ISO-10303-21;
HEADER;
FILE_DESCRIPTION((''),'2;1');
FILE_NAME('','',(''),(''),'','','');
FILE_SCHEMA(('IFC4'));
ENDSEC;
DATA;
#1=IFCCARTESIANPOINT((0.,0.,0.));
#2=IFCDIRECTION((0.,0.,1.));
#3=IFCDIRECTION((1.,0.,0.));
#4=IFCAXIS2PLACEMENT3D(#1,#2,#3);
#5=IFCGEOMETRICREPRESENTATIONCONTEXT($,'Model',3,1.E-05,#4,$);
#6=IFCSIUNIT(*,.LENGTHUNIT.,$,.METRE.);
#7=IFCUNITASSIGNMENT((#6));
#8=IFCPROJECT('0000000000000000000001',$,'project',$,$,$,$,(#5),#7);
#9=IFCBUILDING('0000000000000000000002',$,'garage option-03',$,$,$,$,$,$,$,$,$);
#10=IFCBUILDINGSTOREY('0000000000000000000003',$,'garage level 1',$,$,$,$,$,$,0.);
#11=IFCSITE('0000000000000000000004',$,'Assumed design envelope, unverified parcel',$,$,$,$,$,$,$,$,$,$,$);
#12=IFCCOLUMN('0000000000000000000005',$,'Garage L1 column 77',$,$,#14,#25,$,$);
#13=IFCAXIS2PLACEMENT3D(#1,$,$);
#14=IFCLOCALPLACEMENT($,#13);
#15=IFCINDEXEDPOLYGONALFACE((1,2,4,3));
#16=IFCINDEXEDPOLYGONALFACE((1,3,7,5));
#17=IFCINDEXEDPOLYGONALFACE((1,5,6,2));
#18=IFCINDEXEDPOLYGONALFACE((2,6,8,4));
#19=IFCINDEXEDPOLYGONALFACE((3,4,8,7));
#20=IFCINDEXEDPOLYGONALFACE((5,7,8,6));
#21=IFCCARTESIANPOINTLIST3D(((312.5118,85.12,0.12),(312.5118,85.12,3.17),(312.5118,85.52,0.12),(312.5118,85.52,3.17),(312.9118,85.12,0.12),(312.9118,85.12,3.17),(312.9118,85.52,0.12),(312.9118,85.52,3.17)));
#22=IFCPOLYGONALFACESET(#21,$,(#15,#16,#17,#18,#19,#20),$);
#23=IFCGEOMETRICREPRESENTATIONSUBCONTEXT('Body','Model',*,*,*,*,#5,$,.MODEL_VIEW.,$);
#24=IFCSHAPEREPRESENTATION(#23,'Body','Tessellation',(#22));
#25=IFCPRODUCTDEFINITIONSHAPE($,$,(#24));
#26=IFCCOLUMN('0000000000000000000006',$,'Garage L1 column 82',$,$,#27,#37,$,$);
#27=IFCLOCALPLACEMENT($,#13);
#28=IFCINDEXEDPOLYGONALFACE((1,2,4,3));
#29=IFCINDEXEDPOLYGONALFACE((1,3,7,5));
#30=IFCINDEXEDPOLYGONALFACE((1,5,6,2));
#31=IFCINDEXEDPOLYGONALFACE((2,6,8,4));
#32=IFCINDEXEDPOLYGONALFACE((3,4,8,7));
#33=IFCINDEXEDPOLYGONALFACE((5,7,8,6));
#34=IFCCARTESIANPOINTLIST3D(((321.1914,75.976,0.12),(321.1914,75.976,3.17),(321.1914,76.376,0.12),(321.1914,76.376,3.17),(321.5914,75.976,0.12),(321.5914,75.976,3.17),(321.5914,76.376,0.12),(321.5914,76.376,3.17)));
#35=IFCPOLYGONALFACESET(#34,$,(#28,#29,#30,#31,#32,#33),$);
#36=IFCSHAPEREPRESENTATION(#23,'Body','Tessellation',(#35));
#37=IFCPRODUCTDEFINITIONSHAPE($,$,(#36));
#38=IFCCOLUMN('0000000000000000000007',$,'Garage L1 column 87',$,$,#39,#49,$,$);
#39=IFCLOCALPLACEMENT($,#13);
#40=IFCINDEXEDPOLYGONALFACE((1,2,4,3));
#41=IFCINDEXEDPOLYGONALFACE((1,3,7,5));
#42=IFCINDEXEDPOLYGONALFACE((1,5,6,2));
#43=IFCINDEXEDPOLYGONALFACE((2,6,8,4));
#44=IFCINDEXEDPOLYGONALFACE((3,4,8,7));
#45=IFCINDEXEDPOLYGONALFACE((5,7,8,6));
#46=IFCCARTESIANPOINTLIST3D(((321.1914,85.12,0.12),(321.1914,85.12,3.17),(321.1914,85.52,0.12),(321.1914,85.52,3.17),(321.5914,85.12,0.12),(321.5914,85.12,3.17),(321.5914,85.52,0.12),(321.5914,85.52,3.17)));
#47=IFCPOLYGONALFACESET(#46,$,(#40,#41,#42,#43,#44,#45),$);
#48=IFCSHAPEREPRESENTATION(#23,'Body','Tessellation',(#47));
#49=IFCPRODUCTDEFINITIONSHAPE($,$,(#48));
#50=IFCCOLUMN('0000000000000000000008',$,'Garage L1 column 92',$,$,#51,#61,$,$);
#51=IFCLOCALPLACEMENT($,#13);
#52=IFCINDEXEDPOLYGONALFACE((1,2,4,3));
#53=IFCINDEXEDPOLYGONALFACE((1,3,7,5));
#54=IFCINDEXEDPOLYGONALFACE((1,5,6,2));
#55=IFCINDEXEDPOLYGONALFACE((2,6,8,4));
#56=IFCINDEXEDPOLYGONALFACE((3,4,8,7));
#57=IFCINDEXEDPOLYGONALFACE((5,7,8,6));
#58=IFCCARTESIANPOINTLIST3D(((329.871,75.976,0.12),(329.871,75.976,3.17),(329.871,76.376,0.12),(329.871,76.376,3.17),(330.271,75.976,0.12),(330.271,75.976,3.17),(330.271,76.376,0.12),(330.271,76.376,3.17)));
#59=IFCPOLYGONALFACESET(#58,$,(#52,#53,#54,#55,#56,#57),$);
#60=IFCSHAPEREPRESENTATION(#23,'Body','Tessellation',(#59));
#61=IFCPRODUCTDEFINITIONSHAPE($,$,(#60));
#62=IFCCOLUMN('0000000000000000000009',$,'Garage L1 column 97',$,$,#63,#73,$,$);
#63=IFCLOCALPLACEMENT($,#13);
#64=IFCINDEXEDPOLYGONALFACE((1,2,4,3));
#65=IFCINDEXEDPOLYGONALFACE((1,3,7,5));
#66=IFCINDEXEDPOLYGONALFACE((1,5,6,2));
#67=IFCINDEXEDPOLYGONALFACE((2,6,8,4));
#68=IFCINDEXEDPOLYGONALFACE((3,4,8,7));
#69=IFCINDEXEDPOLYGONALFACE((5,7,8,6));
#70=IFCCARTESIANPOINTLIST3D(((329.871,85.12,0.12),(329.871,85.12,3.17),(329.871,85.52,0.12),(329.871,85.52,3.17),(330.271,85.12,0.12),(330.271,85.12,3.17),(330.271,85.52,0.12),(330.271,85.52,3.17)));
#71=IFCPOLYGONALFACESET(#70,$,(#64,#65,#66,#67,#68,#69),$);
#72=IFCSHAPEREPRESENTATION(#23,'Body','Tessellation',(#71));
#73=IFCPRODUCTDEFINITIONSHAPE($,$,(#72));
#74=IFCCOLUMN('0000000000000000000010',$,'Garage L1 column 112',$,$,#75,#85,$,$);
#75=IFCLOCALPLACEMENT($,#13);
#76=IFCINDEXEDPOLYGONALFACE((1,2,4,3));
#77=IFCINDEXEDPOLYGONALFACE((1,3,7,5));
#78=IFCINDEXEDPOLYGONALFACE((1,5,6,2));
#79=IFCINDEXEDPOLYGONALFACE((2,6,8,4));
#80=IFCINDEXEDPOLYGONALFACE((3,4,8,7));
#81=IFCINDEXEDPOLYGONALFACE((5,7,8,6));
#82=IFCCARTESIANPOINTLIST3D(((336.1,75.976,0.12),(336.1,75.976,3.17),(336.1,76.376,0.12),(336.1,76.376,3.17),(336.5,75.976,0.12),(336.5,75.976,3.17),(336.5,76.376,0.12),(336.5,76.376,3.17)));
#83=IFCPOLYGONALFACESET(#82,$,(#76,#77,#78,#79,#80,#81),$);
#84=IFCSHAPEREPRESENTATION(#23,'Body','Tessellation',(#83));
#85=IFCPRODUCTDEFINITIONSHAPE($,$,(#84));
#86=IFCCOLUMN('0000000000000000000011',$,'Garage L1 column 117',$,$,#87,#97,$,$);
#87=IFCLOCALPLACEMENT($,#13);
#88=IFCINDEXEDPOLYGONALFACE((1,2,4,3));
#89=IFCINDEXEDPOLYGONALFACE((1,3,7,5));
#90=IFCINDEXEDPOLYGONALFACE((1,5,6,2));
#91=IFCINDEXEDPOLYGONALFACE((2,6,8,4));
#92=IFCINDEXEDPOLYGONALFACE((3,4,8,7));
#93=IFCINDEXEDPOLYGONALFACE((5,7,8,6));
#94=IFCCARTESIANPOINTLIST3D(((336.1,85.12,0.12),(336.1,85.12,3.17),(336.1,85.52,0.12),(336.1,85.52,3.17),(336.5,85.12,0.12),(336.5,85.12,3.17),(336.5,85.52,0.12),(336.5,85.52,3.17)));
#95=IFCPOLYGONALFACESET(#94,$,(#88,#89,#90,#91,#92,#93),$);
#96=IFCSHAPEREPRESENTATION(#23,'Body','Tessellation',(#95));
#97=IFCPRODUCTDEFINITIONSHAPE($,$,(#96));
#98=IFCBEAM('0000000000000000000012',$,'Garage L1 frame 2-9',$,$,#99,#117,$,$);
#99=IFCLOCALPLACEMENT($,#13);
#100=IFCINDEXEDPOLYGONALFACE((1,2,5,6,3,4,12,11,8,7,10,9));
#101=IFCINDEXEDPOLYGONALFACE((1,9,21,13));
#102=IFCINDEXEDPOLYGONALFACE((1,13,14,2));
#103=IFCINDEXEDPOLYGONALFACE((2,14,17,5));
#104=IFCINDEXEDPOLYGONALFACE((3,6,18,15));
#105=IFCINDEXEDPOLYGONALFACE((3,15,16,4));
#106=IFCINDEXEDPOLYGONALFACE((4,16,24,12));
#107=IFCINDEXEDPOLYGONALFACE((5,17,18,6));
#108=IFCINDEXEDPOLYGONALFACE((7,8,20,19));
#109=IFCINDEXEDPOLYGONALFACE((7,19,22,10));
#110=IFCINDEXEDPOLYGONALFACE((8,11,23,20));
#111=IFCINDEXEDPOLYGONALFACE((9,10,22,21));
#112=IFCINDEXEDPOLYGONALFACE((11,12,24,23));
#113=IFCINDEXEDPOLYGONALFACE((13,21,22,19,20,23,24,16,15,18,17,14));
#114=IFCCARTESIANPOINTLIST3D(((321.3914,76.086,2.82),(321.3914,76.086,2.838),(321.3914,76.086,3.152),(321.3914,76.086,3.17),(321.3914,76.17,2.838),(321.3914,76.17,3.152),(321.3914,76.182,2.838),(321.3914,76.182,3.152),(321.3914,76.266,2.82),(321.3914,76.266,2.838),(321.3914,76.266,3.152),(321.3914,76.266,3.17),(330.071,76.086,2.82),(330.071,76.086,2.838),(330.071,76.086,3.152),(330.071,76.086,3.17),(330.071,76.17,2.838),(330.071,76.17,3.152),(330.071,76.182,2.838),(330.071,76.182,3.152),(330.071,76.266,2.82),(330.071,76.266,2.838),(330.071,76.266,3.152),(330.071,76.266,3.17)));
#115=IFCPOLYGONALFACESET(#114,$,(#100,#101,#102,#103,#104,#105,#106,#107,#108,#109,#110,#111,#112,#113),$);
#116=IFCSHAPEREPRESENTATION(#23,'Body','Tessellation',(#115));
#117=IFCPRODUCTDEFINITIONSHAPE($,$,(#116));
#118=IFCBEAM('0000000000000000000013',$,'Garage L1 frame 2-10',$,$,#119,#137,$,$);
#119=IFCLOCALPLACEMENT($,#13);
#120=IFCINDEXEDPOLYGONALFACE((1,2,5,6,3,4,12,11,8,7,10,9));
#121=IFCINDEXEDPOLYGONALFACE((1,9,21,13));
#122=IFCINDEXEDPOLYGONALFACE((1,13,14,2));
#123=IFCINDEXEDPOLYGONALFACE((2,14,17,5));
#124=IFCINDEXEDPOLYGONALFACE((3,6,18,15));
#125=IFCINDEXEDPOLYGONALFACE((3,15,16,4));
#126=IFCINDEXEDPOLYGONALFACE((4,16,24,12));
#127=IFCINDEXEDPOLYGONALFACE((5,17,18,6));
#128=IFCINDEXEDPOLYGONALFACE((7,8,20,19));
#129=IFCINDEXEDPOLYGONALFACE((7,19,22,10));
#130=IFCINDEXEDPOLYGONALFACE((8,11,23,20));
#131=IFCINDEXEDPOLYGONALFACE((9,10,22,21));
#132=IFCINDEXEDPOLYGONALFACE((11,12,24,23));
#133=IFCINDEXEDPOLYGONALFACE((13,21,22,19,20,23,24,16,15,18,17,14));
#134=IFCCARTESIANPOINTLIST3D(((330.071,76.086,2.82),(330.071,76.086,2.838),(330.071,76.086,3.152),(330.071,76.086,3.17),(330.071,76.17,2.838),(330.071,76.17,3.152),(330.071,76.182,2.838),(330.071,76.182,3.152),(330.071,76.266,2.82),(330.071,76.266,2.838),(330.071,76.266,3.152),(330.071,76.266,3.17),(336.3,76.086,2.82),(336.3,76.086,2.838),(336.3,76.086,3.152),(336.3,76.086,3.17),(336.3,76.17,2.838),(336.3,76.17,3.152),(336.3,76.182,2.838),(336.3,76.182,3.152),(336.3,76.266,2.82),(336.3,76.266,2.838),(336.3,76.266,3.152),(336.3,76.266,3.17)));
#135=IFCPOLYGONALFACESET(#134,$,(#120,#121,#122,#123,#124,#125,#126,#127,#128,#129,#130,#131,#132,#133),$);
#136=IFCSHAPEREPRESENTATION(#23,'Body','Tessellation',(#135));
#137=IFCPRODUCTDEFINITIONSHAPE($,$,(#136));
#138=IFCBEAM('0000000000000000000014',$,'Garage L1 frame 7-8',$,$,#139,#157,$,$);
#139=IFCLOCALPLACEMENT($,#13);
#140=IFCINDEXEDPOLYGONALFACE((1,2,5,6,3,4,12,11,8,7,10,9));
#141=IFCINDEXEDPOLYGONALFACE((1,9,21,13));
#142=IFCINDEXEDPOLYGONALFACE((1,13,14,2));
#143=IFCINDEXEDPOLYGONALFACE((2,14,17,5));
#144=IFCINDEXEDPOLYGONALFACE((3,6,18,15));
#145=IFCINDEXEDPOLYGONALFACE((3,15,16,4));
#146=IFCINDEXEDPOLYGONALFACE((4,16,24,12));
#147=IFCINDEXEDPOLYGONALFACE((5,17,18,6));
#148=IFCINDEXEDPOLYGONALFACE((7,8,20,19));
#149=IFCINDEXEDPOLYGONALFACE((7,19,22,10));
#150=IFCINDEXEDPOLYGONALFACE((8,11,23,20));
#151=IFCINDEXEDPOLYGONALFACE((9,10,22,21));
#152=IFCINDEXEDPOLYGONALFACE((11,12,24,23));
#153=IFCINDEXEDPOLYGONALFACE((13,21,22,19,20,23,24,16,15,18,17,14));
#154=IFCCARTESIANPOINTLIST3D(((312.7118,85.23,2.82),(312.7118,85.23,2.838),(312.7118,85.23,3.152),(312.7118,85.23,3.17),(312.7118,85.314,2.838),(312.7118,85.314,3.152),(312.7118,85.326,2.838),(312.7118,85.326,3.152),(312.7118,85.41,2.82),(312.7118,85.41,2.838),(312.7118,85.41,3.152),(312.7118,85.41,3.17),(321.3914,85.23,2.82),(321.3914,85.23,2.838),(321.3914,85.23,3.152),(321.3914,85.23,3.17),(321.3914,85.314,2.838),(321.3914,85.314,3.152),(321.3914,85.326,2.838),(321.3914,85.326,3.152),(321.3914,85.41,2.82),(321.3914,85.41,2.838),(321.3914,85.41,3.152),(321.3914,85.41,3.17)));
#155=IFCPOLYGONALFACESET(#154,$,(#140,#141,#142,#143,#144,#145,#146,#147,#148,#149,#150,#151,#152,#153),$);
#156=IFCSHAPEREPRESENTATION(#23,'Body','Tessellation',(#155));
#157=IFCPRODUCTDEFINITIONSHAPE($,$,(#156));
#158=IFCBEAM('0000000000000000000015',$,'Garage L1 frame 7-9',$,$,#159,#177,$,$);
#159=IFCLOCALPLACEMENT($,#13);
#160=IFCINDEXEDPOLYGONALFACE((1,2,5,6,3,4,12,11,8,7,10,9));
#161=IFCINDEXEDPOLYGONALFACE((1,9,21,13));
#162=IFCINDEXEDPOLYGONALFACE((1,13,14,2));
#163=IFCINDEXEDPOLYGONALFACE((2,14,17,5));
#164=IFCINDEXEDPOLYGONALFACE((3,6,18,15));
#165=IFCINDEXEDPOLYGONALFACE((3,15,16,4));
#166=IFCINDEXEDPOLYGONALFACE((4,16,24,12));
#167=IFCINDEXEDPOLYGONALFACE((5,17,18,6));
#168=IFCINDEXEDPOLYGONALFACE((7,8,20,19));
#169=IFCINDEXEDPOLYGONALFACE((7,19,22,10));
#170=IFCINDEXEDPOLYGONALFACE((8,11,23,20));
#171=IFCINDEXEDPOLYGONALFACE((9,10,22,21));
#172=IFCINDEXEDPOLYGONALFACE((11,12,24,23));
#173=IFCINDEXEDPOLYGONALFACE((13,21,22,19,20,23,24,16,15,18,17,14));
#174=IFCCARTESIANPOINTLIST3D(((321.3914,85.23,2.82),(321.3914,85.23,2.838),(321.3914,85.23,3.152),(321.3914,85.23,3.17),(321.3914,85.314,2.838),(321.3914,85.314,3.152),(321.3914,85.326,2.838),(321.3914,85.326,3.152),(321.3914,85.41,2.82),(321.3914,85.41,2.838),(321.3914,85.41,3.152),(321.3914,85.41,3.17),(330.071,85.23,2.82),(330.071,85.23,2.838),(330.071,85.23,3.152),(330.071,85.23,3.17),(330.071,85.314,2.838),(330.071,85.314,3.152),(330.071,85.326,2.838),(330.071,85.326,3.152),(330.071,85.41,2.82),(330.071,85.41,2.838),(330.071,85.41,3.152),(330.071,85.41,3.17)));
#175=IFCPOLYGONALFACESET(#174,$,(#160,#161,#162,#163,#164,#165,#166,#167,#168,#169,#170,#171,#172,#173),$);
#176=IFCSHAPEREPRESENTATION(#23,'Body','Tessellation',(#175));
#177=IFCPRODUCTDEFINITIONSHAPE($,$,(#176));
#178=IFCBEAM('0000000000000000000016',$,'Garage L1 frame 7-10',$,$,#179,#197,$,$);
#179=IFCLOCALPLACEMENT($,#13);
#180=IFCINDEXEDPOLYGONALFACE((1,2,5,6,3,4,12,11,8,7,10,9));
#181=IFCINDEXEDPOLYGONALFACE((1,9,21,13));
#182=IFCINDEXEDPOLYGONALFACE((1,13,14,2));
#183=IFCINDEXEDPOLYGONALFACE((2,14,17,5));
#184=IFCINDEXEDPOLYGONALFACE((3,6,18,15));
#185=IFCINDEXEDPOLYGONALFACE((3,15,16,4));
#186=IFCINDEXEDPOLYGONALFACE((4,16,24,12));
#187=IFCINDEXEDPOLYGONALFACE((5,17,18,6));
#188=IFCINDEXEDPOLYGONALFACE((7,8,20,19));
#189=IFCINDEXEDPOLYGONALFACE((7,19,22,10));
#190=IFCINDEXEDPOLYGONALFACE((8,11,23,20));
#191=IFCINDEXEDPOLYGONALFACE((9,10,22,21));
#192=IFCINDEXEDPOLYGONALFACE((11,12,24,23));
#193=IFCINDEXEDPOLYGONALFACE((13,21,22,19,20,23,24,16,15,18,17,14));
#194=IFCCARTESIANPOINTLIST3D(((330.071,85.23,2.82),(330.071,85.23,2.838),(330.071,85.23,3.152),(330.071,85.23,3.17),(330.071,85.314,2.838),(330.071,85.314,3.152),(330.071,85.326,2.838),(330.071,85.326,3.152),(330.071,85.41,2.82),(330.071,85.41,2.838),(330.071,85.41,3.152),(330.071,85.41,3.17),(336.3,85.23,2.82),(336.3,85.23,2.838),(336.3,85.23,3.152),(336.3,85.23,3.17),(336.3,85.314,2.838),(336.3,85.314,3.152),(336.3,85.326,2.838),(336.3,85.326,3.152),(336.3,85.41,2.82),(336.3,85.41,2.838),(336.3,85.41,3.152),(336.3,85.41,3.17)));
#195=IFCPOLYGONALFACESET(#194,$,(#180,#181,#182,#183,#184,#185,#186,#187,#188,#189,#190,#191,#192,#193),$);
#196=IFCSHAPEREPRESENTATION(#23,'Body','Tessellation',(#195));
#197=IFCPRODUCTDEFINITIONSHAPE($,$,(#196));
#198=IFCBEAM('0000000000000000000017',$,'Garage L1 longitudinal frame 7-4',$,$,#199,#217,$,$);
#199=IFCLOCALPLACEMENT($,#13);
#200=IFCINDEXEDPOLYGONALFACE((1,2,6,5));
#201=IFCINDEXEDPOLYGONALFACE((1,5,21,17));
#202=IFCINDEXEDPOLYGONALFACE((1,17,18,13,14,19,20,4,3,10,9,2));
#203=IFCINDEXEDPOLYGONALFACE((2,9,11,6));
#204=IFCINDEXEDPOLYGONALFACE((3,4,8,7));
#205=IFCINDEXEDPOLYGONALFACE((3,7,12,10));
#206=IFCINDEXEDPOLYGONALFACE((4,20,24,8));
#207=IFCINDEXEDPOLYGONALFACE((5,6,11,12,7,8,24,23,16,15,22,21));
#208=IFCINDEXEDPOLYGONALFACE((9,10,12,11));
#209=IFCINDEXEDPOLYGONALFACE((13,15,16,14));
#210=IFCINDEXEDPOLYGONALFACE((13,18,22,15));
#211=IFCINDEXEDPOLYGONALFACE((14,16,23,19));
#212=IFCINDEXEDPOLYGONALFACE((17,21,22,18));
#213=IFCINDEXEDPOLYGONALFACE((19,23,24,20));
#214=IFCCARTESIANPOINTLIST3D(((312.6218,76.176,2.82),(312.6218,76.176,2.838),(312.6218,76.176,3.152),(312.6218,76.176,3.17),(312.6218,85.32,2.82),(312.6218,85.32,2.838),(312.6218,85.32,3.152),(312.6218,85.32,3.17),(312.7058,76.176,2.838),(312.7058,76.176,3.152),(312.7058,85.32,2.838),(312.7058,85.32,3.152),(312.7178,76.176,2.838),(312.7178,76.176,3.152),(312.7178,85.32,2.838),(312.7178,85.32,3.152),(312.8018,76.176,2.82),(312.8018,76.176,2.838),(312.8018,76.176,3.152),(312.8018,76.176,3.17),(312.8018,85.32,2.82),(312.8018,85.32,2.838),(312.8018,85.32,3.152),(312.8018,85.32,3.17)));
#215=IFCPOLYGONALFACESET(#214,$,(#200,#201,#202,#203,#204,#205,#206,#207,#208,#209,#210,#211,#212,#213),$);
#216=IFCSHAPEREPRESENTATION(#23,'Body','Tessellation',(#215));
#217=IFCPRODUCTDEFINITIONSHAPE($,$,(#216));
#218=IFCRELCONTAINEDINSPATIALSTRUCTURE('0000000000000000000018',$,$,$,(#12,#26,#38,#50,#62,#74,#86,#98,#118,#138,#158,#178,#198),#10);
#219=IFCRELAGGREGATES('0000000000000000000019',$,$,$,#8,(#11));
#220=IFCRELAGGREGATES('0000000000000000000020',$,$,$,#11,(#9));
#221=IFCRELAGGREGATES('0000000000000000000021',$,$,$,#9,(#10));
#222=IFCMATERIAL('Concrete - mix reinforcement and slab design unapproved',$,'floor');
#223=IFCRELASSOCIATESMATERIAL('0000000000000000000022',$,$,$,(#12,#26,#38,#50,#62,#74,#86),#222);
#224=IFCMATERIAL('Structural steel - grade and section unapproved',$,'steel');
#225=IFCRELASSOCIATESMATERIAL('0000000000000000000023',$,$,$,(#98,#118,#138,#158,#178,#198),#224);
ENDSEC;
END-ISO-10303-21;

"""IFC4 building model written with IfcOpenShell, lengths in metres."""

from ifc_helpers import new_model, si_unit, frame, origin_with_axes, place, context, subcontext, project, spatial, rectangle, i_section, extrude, material, element, save


model = new_model("IFC4")

# Units and contexts
model_context = context("Model", 3, precision=1e-05, world=origin_with_axes())
body_context = subcontext(model_context, "Body", "Model", "MODEL_VIEW")
ifc_project = project(units=[si_unit("LENGTHUNIT", "METRE")], contexts=[model_context])

# Site, building, storey
site = spatial("IfcSite", under=ifc_project, Name="Assumed design envelope, unverified parcel")
building = spatial("IfcBuilding", under=site, Name="garage option-03")
storey = spatial("IfcBuildingStorey", under=building, Name="garage level 1", Elevation=0.0)

# Columns
ifc_material_1 = material(Name="Concrete - mix reinforcement and slab design unapproved", Category="floor")
for number, where, z_axis, x_axis, name in (
    (1, (312.7118, 85.32, 0.12), (0.0, 0.0, 1.0), (1.0, 0.0, 0.0), "Garage L1 column 77"),
    (2, (321.3914, 76.176, 0.12), (0.0, 0.0, 1.0), (1.0, 0.0, 0.0), "Garage L1 column 82"),
    (3, (321.3914, 85.32, 0.12), (0.0, 0.0, 1.0), (1.0, 0.0, 0.0), "Garage L1 column 87"),
    (4, (330.071, 76.176, 0.12), (0.0, 0.0, 1.0), (1.0, 0.0, 0.0), "Garage L1 column 92"),
    (5, (330.071, 85.32, 0.12), (0.0, 0.0, 1.0), (1.0, 0.0, 0.0), "Garage L1 column 97"),
    (6, (336.3, 76.176, 0.12), (0.0, 0.0, 1.0), (1.0, 0.0, 0.0), "Garage L1 column 112"),
    (7, (336.3, 85.32, 0.12), (0.0, 0.0, 1.0), (1.0, 0.0, 0.0), "Garage L1 column 117"),
):
    element("IfcColumn", number, at=place(None, frame(where, z_axis=z_axis, x_axis=x_axis)), inside=storey, material=ifc_material_1, Name=name, context=body_context, shape_type="SweptSolid", body=[
        extrude(rectangle(XDim=0.4, YDim=0.4), origin_with_axes(), (0.0, 0.0, 1.0), 3.05),
    ])

# Beams
ifc_material_2 = material(Name="Structural steel - grade and section unapproved", Category="steel")
beam_1_placement = place(None, frame((321.3914, 76.176, 2.995), z_axis=(1.0, 0.0, 0.0), x_axis=(0.0, 1.0, 0.0)))
element("IfcBeam", 8, at=beam_1_placement, inside=storey, material=ifc_material_2, Name="Garage L1 frame 2-9", context=body_context, shape_type="SweptSolid", body=[
    extrude(i_section(OverallWidth=0.18, OverallDepth=0.35, WebThickness=0.012, FlangeThickness=0.018, FilletRadius=0.0), origin_with_axes(), (0.0, 0.0, 1.0), 8.6796),
])
beam_2_placement = place(None, frame((330.071, 76.176, 2.995), z_axis=(1.0, 0.0, 0.0), x_axis=(0.0, 1.0, 0.0)))
element("IfcBeam", 9, at=beam_2_placement, inside=storey, material=ifc_material_2, Name="Garage L1 frame 2-10", context=body_context, shape_type="SweptSolid", body=[
    extrude(i_section(OverallWidth=0.18, OverallDepth=0.35, WebThickness=0.012, FlangeThickness=0.018, FilletRadius=0.0), origin_with_axes(), (0.0, 0.0, 1.0), 6.229),
])
beam_3_placement = place(None, frame((312.7118, 85.32, 2.995), z_axis=(1.0, 0.0, 0.0), x_axis=(0.0, 1.0, 0.0)))
element("IfcBeam", 10, at=beam_3_placement, inside=storey, material=ifc_material_2, Name="Garage L1 frame 7-8", context=body_context, shape_type="SweptSolid", body=[
    extrude(i_section(OverallWidth=0.18, OverallDepth=0.35, WebThickness=0.012, FlangeThickness=0.018, FilletRadius=0.0), origin_with_axes(), (0.0, 0.0, 1.0), 8.6796),
])
beam_4_placement = place(None, frame((321.3914, 85.32, 2.995), z_axis=(1.0, 0.0, 0.0), x_axis=(0.0, 1.0, 0.0)))
element("IfcBeam", 11, at=beam_4_placement, inside=storey, material=ifc_material_2, Name="Garage L1 frame 7-9", context=body_context, shape_type="SweptSolid", body=[
    extrude(i_section(OverallWidth=0.18, OverallDepth=0.35, WebThickness=0.012, FlangeThickness=0.018, FilletRadius=0.0), origin_with_axes(), (0.0, 0.0, 1.0), 8.6796),
])
beam_5_placement = place(None, frame((330.071, 85.32, 2.995), z_axis=(1.0, 0.0, 0.0), x_axis=(0.0, 1.0, 0.0)))
element("IfcBeam", 12, at=beam_5_placement, inside=storey, material=ifc_material_2, Name="Garage L1 frame 7-10", context=body_context, shape_type="SweptSolid", body=[
    extrude(i_section(OverallWidth=0.18, OverallDepth=0.35, WebThickness=0.012, FlangeThickness=0.018, FilletRadius=0.0), origin_with_axes(), (0.0, 0.0, 1.0), 6.229),
])
for number, where, z_axis, x_axis, name in (
    (13, (312.7118, 76.176, 2.995), (0.0, 1.0, 0.0), (-1.0, 0.0, 0.0), "Garage L1 longitudinal frame 7-4"),
):
    element("IfcBeam", number, at=place(None, frame(where, z_axis=z_axis, x_axis=x_axis)), inside=storey, material=ifc_material_2, Name=name, context=body_context, shape_type="SweptSolid", body=[
        extrude(i_section(OverallWidth=0.18, OverallDepth=0.35, WebThickness=0.012, FlangeThickness=0.018, FilletRadius=0.0), origin_with_axes(), (0.0, 0.0, 1.0), 9.144),
    ])

save(model, "model.ifc")
